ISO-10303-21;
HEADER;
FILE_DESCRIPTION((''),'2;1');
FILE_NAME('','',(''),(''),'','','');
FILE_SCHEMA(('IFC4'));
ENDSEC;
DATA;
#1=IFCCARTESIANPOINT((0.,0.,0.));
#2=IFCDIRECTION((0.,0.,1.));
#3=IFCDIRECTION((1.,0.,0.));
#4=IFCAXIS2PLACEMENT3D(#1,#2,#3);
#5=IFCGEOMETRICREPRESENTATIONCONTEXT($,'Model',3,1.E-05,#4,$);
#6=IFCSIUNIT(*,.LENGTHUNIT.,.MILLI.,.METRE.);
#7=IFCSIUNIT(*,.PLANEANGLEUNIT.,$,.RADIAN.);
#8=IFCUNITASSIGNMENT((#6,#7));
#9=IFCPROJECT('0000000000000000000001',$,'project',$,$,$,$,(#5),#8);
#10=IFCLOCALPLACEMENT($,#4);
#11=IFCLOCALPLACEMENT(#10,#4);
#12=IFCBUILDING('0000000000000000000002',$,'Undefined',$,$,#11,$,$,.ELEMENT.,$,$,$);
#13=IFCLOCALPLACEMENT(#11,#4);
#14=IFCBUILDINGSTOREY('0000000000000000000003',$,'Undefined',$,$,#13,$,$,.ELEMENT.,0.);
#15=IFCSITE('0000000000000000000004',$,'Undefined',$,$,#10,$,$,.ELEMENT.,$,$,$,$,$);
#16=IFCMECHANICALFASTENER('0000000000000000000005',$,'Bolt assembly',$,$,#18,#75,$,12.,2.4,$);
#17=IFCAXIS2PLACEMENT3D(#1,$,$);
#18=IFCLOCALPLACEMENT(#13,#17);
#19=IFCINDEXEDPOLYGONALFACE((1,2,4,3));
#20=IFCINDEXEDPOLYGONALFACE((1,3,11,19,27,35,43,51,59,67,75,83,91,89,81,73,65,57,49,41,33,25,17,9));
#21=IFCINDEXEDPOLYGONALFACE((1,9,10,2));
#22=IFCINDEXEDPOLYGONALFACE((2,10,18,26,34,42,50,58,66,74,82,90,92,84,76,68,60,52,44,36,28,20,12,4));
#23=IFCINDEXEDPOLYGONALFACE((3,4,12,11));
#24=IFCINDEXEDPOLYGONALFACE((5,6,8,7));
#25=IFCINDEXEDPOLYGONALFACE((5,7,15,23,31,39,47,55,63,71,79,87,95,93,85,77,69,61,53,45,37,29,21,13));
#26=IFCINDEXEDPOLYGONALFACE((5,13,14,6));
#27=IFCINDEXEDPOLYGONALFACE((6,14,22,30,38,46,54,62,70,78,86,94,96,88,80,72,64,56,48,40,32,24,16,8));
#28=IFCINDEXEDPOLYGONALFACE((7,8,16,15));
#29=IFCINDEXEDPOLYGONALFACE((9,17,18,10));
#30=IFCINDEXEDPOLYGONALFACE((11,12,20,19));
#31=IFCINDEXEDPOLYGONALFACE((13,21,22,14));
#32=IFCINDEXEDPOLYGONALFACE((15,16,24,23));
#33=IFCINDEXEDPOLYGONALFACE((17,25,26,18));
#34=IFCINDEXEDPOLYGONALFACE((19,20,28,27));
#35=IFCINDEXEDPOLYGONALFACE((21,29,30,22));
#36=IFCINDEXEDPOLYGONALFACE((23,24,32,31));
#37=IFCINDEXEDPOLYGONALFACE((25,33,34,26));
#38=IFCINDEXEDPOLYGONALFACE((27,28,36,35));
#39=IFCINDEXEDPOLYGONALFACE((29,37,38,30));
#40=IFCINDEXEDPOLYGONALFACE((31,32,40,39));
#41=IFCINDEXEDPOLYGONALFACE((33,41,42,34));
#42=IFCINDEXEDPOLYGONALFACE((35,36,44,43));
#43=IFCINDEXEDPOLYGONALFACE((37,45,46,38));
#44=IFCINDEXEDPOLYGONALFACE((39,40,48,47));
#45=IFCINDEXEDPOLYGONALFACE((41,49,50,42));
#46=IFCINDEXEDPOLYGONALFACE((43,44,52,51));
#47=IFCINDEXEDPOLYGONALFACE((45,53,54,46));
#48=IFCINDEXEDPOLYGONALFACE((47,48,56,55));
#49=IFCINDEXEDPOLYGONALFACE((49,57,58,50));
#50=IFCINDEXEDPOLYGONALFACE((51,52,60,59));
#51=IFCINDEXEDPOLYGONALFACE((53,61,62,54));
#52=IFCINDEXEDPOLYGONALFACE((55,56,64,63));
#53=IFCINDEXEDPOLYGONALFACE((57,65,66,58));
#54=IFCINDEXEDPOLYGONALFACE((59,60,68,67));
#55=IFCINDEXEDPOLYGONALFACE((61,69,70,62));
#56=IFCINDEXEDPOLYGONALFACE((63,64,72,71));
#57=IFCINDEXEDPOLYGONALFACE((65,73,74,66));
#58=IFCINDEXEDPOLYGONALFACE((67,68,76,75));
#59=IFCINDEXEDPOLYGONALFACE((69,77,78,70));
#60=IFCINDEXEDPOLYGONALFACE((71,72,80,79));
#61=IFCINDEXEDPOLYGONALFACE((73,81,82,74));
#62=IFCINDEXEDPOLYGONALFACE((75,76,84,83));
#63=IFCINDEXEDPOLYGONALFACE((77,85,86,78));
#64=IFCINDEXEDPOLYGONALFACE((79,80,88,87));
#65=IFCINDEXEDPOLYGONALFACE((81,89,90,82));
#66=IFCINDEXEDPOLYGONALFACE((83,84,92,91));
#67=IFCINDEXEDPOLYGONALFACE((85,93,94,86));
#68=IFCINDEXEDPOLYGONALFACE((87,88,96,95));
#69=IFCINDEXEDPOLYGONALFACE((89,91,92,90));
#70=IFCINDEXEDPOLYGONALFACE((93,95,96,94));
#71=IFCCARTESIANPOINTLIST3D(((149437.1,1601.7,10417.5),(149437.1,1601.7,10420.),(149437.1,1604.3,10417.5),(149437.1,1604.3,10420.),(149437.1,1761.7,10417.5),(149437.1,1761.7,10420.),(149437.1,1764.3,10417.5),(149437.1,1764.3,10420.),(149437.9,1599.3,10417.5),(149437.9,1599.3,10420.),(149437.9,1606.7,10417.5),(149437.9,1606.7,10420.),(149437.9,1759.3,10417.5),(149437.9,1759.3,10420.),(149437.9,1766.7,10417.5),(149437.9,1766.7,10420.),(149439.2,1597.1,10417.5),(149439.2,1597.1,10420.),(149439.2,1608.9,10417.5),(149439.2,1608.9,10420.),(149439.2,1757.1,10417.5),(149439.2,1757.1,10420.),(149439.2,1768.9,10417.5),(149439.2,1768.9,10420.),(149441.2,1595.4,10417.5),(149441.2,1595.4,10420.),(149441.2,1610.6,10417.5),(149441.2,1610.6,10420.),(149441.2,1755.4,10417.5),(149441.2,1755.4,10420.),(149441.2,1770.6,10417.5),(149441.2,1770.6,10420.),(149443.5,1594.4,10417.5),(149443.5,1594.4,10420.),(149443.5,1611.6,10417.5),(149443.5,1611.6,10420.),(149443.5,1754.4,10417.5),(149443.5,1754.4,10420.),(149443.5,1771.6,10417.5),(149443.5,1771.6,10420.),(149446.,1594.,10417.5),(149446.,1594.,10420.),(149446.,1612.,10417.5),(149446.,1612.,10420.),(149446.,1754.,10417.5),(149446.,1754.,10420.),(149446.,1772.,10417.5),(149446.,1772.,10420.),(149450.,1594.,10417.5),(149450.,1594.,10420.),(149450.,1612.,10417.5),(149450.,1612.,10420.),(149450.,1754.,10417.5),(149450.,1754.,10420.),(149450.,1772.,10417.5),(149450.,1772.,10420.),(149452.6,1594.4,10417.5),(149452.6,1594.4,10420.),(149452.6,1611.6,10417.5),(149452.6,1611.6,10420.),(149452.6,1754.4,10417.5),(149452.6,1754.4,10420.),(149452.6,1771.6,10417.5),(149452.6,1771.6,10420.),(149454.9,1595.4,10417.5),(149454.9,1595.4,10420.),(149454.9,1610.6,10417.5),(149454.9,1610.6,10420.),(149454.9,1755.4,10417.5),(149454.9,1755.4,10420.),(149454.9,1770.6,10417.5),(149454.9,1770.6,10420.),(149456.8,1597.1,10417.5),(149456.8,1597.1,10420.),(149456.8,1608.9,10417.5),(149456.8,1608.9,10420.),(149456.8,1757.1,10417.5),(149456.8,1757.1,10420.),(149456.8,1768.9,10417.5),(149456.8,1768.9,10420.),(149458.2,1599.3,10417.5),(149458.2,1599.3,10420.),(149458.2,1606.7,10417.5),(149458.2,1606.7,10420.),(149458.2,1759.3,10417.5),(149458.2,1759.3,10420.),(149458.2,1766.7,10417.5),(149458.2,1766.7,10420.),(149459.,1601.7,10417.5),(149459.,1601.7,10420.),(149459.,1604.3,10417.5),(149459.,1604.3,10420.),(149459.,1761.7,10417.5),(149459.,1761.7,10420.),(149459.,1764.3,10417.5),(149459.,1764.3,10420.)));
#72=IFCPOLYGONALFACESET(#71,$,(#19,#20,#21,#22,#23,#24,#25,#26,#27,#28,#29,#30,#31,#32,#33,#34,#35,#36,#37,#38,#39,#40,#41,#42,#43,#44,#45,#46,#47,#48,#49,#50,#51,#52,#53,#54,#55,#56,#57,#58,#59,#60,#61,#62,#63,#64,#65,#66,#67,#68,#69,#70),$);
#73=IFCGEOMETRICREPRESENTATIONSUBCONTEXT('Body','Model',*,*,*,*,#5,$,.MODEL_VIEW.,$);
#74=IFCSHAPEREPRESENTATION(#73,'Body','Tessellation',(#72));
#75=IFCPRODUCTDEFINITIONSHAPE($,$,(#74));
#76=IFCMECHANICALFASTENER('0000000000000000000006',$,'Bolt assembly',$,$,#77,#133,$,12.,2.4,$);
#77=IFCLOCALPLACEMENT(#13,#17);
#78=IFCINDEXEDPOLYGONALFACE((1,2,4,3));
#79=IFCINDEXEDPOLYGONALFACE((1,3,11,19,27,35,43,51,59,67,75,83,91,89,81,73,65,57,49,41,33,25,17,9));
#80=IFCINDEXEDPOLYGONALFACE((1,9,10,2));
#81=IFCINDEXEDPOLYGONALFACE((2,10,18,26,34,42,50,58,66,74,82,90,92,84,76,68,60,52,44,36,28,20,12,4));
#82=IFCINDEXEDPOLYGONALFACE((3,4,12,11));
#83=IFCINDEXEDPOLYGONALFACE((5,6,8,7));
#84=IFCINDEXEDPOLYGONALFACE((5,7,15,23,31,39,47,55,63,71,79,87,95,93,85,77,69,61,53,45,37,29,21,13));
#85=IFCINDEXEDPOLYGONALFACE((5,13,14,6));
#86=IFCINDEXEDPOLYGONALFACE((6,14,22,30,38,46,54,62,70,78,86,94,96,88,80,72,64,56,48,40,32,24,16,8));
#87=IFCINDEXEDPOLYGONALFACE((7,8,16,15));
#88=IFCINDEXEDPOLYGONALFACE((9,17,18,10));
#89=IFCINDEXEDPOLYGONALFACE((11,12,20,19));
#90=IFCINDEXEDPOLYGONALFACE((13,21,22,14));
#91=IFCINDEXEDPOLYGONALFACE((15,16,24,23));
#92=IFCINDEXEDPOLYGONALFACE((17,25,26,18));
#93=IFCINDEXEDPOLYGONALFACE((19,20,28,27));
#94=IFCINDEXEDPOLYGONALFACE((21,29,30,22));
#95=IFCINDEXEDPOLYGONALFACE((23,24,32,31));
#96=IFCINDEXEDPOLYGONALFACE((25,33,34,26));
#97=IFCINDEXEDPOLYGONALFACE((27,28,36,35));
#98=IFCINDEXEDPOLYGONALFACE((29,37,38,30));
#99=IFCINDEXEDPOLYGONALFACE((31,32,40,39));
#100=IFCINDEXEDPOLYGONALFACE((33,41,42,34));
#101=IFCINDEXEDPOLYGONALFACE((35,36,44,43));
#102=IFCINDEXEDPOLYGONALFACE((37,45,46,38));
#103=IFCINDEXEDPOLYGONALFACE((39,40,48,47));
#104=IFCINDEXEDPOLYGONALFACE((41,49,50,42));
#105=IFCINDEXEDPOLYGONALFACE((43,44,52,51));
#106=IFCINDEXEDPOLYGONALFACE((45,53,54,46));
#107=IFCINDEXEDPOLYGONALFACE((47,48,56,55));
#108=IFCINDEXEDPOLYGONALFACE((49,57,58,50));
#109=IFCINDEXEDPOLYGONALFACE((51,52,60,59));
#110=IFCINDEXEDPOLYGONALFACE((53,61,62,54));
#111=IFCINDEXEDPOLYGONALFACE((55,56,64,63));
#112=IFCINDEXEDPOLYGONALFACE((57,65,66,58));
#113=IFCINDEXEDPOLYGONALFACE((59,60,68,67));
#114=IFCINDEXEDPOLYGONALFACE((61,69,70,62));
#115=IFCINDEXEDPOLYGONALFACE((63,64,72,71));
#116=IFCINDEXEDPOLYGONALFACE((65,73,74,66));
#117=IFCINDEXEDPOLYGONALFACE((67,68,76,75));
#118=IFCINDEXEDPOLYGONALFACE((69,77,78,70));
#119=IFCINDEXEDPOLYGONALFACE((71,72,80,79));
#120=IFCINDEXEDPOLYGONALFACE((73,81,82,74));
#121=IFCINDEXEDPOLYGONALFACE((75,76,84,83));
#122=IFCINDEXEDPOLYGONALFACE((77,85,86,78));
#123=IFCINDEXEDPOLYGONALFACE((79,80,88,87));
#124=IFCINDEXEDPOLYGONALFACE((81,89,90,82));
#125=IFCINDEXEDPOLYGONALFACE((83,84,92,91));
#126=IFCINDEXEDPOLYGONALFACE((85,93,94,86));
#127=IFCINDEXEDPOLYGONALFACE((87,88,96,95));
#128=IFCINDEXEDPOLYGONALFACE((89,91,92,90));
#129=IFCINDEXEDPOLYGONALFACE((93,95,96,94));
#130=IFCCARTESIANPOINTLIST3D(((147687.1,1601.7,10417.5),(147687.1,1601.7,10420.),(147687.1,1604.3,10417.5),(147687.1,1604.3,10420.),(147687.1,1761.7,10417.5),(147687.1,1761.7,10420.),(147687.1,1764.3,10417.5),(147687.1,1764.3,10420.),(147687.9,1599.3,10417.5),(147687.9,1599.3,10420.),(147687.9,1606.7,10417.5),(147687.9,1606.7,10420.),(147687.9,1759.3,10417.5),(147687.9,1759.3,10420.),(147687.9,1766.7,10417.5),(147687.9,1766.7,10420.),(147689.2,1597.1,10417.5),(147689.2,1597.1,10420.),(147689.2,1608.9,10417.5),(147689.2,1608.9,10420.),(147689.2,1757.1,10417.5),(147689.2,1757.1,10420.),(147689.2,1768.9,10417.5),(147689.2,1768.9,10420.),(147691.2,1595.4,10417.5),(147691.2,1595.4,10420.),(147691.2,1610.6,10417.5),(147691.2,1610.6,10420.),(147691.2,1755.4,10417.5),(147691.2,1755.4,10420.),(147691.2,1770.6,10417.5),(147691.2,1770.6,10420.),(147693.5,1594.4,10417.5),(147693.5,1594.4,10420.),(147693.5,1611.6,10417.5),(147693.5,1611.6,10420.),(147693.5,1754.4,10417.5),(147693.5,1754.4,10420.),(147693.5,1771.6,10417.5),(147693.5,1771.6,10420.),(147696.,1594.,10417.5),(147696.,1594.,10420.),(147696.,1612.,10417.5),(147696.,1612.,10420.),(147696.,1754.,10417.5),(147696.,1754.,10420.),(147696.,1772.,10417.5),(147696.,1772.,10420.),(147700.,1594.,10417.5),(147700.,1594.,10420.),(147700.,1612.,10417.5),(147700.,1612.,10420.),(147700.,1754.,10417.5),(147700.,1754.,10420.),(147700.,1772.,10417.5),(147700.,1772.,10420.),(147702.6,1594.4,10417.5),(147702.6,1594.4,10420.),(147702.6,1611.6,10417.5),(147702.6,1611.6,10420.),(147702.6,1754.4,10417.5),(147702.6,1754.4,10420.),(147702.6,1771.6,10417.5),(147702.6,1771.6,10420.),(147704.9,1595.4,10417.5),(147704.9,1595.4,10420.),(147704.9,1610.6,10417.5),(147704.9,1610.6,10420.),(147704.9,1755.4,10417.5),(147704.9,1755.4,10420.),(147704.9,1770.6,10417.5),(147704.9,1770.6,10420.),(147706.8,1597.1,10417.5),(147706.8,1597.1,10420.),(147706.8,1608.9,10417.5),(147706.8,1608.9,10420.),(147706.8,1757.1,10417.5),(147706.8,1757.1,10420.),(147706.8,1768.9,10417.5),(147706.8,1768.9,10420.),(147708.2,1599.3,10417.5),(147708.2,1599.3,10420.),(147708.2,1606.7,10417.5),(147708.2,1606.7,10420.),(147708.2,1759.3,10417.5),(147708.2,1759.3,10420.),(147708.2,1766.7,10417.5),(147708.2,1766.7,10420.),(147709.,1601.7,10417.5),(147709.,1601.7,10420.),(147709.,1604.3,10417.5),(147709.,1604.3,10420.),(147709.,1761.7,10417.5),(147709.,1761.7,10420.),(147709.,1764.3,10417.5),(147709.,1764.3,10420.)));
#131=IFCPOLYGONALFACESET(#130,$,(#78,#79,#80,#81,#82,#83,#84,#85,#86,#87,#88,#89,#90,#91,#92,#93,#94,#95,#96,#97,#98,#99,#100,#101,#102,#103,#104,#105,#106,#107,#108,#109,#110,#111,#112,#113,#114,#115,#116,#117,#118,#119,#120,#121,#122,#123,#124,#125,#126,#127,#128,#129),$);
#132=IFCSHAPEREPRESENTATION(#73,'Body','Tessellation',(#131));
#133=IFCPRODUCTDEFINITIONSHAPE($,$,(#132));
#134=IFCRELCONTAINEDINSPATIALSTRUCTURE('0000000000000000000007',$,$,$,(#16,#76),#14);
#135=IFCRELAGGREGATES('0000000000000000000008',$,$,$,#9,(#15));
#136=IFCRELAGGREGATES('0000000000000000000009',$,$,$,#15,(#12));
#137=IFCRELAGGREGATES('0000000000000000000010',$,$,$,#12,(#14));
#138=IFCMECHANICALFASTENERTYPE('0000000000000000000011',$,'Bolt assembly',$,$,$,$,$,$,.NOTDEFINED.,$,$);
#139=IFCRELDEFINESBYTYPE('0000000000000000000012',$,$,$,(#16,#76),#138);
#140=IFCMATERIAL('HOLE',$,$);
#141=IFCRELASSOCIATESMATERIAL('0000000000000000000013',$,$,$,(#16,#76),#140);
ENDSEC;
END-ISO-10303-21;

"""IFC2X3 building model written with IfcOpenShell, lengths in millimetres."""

from ifc_helpers import new_model, si_unit, frame, frame_2d, origin_with_axes, place, context, subcontext, project, spatial, polyline, circle_curve, parameter, trimmed, segment, composite_curve, outline, extrude, source, transform, mapped, material, type_object, element, save


model = new_model("IFC2X3")

# Units and contexts
model_context = context("Model", 3, precision=1e-05, world=origin_with_axes())
body_context = subcontext(model_context, "Body", "Model", "MODEL_VIEW")
ifc_project = project(units=[si_unit("LENGTHUNIT", "METRE", prefix="MILLI"), si_unit("PLANEANGLEUNIT", "RADIAN")], contexts=[model_context])

# Site, building, storey
site_placement = place(None, origin_with_axes())
site = spatial("IfcSite", under=ifc_project, at=site_placement, Name="Undefined", CompositionType="ELEMENT")
building_placement = place(site_placement, origin_with_axes())
building = spatial("IfcBuilding", under=site, at=building_placement, Name="Undefined", CompositionType="ELEMENT")
storey_placement = place(building_placement, origin_with_axes())
storey = spatial("IfcBuildingStorey", under=building, at=storey_placement, Name="Undefined", CompositionType="ELEMENT", Elevation=0.0)

# Mechanical fasteners
mechanical_fastener_type = type_object("IfcMechanicalFastenerType", Name="Bolt assembly")
ifc_material_1 = material(Name="HOLE")
shared_shape_1 = source(origin_with_axes(), body_context, "Body", "SweptSolid", [
    extrude(outline(composite_curve([segment(polyline([(-2.0, 9.0), (2.0, 9.0)]), True, "CONTINUOUS"), segment(trimmed(circle_curve(frame_2d((2.0, 0.0), x_axis=(0.0, 1.0)), 9.0), [parameter(0.0)], [parameter(3.141593)], False, "PARAMETER"), True, "CONTINUOUS"), segment(polyline([(2.0, -9.0), (-2.0, -9.0)]), True, "CONTINUOUS"), segment(trimmed(circle_curve(frame_2d((-2.0, 0.0), x_axis=(0.0, -1.0)), 9.0), [parameter(0.0)], [parameter(3.141593)], False, "PARAMETER"), True, "DISCONTINUOUS")], self_intersect=False)), frame((0.0, -2.4, 0.0), z_axis=(0.0, 1.0, 0.0), x_axis=(1.0, 0.0, 0.0)), (0.0, 0.0, 1.0), 2.5),
])
mechanical_fastener_1_placement = place(storey_placement, frame((149448.0, 1683.0, 10417.6), z_axis=(0.0, -1.0, 0.0), x_axis=(-1.0, 0.0, 0.0)))
element("IfcMechanicalFastener", 1, at=mechanical_fastener_1_placement, inside=storey, type_object=mechanical_fastener_type, material=ifc_material_1, Name="Bolt assembly", NominalDiameter=12.0, NominalLength=2.4, context=body_context, shape_type="MappedRepresentation", body=[
    mapped(shared_shape_1, transform((0.0, 0.0, -80.0))),
    mapped(shared_shape_1, transform((0.0, 0.0, 80.0))),
])
shared_shape_2 = source(origin_with_axes(), body_context, "Body", "SweptSolid", [
    extrude(outline(composite_curve([segment(polyline([(-2.0, 9.0), (2.0, 9.0)]), True, "CONTINUOUS"), segment(trimmed(circle_curve(frame_2d((2.0, 0.0), x_axis=(0.0, 1.0)), 9.0), [parameter(0.0)], [parameter(3.141593)], False, "PARAMETER"), True, "CONTINUOUS"), segment(polyline([(2.0, -9.0), (-2.0, -9.0)]), True, "CONTINUOUS"), segment(trimmed(circle_curve(frame_2d((-2.0, 0.0), x_axis=(0.0, -1.0)), 9.0), [parameter(0.0)], [parameter(3.141593)], False, "PARAMETER"), True, "DISCONTINUOUS")], self_intersect=False)), frame((0.0, -2.4, 0.0), z_axis=(0.0, 1.0, 0.0), x_axis=(1.0, 0.0, 0.0)), (0.0, 0.0, 1.0), 2.5),
])
mechanical_fastener_2_placement = place(storey_placement, frame((147698.0, 1683.0, 10417.6), z_axis=(0.0, -1.0, 0.0), x_axis=(-1.0, 0.0, 0.0)))
element("IfcMechanicalFastener", 2, at=mechanical_fastener_2_placement, inside=storey, type_object=mechanical_fastener_type, material=ifc_material_1, Name="Bolt assembly", NominalDiameter=12.0, NominalLength=2.4, context=body_context, shape_type="MappedRepresentation", body=[
    mapped(shared_shape_2, transform((0.0, 0.0, -80.0))),
    mapped(shared_shape_2, transform((0.0, 0.0, 80.0))),
])

save(model, "model.ifc")
